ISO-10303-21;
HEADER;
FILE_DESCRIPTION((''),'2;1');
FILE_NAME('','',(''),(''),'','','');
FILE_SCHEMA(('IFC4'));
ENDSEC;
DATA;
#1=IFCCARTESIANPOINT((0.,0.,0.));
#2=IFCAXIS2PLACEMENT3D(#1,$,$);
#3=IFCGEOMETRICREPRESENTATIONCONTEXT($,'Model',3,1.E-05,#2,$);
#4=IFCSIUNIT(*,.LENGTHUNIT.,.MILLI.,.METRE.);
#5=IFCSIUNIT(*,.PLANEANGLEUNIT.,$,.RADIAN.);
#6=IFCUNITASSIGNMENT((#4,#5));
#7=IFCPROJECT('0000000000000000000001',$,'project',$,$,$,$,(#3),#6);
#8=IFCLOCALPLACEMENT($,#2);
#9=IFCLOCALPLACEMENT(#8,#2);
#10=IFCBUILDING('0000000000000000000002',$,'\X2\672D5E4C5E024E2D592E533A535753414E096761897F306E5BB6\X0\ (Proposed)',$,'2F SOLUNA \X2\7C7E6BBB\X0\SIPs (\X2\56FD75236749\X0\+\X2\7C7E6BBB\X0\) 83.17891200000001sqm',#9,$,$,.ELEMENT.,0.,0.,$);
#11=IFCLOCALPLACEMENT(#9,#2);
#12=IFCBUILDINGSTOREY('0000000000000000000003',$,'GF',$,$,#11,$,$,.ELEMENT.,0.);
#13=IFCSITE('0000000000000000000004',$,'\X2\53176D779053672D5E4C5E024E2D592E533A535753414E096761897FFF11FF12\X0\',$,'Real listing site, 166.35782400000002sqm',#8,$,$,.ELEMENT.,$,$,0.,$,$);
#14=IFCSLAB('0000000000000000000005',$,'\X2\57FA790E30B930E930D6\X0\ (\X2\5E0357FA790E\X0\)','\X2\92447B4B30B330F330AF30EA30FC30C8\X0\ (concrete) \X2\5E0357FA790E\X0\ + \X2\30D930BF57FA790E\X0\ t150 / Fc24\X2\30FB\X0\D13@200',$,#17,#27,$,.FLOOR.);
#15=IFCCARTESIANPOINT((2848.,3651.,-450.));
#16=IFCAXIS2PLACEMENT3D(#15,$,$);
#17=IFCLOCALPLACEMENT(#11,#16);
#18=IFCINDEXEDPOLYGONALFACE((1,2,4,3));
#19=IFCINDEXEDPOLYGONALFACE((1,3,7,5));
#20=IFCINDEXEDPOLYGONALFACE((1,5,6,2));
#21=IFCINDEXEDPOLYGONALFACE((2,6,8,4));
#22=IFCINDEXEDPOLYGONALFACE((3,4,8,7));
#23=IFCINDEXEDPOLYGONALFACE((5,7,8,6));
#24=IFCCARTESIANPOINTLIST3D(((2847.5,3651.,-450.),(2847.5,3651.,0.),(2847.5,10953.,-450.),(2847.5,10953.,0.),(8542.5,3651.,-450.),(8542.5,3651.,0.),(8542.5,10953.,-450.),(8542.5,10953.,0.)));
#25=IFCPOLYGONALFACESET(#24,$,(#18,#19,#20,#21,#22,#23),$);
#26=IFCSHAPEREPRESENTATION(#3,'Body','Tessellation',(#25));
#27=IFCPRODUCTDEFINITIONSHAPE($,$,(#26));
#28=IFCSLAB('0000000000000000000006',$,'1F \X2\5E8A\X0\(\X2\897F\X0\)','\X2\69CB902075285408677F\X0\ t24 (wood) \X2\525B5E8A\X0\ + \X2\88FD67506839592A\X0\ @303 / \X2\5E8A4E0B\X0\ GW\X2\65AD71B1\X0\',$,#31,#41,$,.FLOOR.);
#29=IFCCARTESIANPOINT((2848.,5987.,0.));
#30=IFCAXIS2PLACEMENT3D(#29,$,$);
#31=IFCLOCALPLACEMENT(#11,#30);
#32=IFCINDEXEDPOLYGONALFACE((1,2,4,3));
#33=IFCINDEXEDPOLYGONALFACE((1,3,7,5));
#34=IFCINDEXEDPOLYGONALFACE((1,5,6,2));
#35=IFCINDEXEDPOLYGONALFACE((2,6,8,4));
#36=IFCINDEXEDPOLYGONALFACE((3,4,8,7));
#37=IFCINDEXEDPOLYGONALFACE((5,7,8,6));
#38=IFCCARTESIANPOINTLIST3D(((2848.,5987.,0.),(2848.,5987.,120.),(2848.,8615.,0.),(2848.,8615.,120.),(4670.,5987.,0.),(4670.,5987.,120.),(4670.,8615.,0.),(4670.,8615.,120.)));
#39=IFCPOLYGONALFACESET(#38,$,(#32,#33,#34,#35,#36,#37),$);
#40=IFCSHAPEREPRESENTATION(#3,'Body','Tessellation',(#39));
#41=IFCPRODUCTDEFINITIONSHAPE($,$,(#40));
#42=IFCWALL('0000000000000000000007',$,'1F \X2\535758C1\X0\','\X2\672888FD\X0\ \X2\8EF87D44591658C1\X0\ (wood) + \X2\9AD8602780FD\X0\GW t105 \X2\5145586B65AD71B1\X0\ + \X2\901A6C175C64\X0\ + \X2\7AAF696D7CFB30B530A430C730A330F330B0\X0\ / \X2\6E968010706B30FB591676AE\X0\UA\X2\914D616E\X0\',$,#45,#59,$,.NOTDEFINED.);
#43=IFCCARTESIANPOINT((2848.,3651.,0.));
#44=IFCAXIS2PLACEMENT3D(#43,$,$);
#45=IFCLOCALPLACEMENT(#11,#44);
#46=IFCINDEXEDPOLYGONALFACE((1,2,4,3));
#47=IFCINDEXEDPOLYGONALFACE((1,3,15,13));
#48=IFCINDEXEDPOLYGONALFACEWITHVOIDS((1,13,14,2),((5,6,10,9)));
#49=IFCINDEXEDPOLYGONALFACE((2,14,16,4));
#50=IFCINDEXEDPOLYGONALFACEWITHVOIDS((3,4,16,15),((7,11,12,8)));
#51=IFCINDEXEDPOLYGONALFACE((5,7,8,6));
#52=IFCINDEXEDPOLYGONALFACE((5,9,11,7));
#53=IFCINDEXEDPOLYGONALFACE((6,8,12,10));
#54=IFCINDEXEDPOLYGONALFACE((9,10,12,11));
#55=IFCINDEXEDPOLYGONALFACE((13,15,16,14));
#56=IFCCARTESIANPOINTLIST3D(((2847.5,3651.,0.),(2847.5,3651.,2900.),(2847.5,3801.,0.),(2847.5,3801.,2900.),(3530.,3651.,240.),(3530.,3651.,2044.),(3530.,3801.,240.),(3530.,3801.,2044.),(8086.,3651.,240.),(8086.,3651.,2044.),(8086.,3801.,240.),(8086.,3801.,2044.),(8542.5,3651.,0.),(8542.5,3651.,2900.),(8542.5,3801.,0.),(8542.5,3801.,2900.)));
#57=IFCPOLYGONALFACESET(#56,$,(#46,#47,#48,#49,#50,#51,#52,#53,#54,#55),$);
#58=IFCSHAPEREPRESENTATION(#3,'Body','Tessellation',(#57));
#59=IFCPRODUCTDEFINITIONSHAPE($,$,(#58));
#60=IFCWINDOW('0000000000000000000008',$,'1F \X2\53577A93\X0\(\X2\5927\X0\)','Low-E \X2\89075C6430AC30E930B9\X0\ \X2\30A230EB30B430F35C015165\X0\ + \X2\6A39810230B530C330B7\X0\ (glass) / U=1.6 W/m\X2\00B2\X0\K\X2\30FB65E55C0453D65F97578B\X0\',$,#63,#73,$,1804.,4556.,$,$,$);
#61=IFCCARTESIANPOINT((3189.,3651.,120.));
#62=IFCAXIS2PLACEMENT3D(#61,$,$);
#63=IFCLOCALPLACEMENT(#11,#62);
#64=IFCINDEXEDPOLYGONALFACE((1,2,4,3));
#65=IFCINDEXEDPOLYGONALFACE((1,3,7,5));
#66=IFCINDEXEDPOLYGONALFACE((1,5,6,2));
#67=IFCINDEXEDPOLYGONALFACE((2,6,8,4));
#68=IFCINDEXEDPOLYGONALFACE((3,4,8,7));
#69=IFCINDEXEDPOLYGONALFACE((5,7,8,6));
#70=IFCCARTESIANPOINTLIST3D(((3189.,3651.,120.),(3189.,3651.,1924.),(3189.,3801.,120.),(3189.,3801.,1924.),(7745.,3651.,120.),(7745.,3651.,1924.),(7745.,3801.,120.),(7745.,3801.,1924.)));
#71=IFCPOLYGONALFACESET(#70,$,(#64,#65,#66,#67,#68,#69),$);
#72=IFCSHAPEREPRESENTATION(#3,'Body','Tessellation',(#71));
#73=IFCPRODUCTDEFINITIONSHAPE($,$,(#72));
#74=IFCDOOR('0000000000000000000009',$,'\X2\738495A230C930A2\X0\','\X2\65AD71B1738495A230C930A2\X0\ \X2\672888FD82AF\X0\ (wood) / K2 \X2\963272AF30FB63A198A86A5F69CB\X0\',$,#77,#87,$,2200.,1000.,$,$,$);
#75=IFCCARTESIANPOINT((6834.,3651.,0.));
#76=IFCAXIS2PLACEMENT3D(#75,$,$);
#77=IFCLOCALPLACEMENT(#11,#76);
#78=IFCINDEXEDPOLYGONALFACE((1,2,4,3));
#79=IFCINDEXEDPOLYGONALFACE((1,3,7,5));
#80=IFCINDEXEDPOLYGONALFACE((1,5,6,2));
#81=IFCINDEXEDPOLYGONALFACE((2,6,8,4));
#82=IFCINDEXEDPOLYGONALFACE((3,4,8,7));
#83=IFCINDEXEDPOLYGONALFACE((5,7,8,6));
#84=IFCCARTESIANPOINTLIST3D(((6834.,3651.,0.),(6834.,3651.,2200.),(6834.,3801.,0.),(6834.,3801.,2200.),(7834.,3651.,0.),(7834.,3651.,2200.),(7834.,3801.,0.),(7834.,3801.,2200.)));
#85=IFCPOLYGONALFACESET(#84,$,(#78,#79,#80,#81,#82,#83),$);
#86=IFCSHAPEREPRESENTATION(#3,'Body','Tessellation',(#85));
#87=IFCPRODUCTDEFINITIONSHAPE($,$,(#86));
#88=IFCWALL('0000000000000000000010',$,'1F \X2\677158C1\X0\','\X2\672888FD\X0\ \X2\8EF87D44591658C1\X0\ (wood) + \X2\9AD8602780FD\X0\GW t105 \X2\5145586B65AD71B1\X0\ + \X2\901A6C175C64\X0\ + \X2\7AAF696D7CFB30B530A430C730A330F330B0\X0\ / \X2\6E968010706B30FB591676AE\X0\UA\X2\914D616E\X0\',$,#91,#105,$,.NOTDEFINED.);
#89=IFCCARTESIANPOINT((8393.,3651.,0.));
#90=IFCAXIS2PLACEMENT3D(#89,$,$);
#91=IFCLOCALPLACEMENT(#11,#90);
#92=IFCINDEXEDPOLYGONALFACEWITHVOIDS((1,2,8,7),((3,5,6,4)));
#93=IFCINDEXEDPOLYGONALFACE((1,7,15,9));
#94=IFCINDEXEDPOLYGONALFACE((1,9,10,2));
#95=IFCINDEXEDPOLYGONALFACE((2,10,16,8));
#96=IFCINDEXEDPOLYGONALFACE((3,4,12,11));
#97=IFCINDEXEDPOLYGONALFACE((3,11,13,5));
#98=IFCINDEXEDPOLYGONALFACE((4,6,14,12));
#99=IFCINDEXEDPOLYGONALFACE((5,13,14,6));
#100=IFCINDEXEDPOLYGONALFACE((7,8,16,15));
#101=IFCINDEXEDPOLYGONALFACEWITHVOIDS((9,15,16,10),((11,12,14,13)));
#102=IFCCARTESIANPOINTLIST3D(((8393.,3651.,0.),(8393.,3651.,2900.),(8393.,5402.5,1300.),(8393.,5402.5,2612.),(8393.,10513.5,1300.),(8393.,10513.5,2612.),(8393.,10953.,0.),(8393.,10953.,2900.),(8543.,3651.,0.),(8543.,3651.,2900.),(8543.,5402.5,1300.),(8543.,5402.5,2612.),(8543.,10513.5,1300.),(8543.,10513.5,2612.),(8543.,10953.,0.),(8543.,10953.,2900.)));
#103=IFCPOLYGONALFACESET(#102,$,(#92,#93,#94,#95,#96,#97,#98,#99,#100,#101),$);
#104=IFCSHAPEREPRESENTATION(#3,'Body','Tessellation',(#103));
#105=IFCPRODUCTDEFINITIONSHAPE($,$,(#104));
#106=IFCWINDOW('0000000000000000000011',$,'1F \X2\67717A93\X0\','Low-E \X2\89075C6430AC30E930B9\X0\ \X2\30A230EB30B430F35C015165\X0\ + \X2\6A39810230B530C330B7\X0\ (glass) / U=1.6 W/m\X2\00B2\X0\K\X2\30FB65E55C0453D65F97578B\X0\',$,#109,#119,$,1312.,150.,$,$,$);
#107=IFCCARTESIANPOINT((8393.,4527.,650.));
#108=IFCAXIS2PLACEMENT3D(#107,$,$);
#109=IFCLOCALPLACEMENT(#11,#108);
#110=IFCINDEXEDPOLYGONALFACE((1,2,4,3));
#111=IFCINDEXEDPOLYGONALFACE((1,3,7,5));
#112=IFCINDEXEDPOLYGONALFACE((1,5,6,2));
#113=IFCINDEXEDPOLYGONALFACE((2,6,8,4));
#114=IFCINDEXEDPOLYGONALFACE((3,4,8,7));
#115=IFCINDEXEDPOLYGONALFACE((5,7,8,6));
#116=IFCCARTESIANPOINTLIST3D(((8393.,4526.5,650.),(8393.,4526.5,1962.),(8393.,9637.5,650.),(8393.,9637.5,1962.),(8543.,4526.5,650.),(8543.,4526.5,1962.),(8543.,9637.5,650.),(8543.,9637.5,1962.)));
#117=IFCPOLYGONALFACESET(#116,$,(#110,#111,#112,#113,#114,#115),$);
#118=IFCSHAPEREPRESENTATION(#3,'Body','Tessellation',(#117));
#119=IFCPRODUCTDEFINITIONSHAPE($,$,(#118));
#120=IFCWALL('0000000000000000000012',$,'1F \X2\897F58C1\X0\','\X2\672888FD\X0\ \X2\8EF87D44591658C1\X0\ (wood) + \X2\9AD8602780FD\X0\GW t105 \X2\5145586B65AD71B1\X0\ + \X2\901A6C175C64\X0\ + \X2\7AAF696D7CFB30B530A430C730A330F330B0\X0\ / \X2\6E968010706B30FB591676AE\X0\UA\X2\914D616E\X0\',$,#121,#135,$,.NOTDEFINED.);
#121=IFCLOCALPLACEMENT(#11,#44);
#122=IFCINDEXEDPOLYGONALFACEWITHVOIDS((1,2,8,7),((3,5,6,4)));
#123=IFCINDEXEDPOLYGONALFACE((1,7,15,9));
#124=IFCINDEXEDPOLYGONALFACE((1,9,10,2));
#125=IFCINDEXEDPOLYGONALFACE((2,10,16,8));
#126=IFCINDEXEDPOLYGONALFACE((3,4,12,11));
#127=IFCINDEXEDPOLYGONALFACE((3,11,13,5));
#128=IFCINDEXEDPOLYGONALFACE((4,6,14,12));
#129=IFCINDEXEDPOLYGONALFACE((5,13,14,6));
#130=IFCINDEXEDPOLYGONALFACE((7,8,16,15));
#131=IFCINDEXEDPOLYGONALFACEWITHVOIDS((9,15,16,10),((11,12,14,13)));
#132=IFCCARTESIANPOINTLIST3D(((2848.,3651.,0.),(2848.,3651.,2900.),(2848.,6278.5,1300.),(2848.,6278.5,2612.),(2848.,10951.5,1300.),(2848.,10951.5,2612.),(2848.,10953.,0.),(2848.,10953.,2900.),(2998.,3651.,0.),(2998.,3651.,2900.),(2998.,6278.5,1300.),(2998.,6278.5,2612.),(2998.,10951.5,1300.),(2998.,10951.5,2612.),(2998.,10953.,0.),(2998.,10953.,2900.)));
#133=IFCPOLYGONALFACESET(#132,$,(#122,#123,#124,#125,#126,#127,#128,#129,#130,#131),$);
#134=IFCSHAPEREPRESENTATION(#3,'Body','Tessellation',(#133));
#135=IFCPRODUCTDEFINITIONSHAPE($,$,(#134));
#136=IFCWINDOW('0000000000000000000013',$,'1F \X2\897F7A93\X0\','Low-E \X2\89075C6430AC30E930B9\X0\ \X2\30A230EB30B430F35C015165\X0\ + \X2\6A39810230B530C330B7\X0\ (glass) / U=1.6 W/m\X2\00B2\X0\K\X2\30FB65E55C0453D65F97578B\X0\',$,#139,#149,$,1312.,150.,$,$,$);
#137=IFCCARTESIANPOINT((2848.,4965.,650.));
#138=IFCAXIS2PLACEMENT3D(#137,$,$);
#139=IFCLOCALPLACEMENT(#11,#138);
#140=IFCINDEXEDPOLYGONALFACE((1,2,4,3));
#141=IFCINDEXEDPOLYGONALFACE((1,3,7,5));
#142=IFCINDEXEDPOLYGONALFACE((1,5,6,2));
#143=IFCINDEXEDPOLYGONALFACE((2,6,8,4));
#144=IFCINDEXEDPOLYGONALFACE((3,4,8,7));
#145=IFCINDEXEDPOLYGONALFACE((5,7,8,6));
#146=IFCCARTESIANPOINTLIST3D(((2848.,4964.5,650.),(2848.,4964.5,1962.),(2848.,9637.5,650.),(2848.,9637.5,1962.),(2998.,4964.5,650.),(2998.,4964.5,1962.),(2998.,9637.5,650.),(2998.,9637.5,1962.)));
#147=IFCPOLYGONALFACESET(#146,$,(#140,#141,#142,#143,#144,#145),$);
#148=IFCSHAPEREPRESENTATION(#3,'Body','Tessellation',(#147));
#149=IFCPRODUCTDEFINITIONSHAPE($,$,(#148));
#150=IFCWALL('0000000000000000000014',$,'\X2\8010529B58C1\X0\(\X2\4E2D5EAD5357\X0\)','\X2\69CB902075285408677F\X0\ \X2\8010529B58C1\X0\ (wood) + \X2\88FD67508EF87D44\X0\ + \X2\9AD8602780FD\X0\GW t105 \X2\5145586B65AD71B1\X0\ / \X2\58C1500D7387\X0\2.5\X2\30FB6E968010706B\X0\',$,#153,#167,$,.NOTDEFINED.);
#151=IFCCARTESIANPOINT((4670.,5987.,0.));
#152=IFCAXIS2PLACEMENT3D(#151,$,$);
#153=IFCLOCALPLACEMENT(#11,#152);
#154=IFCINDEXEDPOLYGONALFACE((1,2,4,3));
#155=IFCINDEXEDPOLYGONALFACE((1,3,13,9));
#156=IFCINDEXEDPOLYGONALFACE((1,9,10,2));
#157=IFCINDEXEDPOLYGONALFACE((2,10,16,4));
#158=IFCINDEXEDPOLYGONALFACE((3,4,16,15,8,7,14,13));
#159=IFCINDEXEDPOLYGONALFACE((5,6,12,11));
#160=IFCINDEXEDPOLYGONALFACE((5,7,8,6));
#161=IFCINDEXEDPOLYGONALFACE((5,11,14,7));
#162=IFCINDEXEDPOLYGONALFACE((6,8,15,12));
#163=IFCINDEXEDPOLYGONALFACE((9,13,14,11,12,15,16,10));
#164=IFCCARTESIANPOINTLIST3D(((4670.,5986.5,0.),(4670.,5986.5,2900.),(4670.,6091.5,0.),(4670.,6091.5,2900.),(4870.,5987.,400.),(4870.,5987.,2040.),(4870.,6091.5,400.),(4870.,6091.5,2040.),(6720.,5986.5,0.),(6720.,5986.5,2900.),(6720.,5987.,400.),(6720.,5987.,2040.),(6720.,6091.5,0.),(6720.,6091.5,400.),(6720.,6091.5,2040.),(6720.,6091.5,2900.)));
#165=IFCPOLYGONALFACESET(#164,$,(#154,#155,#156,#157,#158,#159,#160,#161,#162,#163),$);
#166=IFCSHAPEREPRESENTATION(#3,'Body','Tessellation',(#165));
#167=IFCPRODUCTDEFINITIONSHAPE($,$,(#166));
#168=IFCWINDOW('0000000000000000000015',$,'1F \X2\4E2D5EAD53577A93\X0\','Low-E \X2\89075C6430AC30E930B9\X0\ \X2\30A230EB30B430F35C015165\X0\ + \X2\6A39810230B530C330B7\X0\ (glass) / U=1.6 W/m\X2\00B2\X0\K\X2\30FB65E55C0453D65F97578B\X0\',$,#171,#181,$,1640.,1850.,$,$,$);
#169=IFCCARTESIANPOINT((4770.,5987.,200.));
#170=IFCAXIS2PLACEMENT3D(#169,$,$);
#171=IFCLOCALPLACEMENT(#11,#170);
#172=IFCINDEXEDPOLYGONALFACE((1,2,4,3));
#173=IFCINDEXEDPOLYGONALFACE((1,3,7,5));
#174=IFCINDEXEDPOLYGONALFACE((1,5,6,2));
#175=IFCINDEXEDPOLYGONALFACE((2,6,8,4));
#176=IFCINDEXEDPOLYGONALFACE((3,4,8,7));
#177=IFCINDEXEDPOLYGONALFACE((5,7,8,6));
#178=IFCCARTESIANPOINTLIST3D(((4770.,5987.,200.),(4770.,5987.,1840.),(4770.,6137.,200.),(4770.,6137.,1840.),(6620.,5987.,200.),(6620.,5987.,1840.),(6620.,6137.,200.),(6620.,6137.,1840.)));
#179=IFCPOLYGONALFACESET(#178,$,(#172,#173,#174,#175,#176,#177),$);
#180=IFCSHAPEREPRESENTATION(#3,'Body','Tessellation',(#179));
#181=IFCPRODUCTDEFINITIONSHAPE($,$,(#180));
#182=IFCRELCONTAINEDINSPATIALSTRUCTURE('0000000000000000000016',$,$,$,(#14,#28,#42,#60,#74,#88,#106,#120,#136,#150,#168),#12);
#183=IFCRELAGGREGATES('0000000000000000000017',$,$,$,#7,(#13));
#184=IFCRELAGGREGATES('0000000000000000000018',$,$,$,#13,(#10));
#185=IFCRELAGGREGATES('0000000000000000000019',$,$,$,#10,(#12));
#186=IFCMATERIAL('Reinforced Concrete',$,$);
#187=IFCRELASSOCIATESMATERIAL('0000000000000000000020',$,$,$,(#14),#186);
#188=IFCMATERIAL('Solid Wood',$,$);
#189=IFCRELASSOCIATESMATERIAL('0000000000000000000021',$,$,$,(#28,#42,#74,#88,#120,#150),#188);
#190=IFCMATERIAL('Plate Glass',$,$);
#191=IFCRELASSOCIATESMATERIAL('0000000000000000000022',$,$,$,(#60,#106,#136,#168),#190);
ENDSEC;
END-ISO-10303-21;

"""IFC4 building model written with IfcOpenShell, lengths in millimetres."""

from ifc_helpers import new_model, si_unit, frame, frame_2d, origin, place, context, project, spatial, rectangle, extrude, material, element, fill, save


model = new_model("IFC4")

# Units and contexts
model_context = context("Model", 3, precision=1e-05, world=origin())
ifc_project = project(units=[si_unit("LENGTHUNIT", "METRE", prefix="MILLI"), si_unit("PLANEANGLEUNIT", "RADIAN")], contexts=[model_context])

# Site, building, storey
site_placement = place(None, origin())
site = spatial("IfcSite", under=ifc_project, at=site_placement, Name="北海道札幌市中央区南十三条西１２", ObjectType="Real listing site, 166.35782400000002sqm", CompositionType="ELEMENT", RefElevation=0.0)
building_placement = place(site_placement, origin())
building = spatial("IfcBuilding", under=site, at=building_placement, Name="札幌市中央区南十三条西の家 (Proposed)", ObjectType="2F SOLUNA 籾殻SIPs (国産杉+籾殻) 83.17891200000001sqm", CompositionType="ELEMENT", ElevationOfRefHeight=0.0, ElevationOfTerrain=0.0)
storey_placement = place(building_placement, origin())
storey = spatial("IfcBuildingStorey", under=building, at=storey_placement, Name="GF", CompositionType="ELEMENT", Elevation=0.0)

# Slabs
ifc_material_1 = material(Name="Reinforced Concrete")
slab_1_placement = place(storey_placement, frame((2848.0, 3651.0, -450.0)))
element("IfcSlab", 1, at=slab_1_placement, inside=storey, material=ifc_material_1, Name="基礎スラブ (布基礎)", Description="鉄筋コンクリート (concrete) 布基礎 + ベタ基礎 t150 / Fc24・D13@200", PredefinedType="FLOOR", context=model_context, shape_type="SweptSolid", body=[
    extrude(rectangle(XDim=5695.0, YDim=7302.0, at=frame_2d((2847.0, 3651.0))), frame((2848.0, 3651.0, -450.0)), (0.0, 0.0, 1.0), 450.0),
])
ifc_material_2 = material(Name="Solid Wood")
slab_2_placement = place(storey_placement, frame((2848.0, 5987.0, 0.0)))
element("IfcSlab", 2, at=slab_2_placement, inside=storey, material=ifc_material_2, Name="1F 床(西)", Description="構造用合板 t24 (wood) 剛床 + 製材根太 @303 / 床下 GW断熱", PredefinedType="FLOOR", context=model_context, shape_type="SweptSolid", body=[
    extrude(rectangle(XDim=1822.0, YDim=2628.0, at=frame_2d((911.0, 1314.0))), frame((2848.0, 5987.0, 0.0)), (0.0, 0.0, 1.0), 120.0),
])

# Wall, openings, window, door
wall_1_placement = place(storey_placement, frame((2848.0, 3651.0, 0.0)))
wall_1 = element("IfcWall", 3, at=wall_1_placement, inside=storey, material=ifc_material_2, Name="1F 南壁", Description="木製 軸組外壁 (wood) + 高性能GW t105 充填断熱 + 通気層 + 窯業系サイディング / 準耐火・外皮UA配慮", PredefinedType="NOTDEFINED", context=model_context, shape_type="SweptSolid", body=[
    extrude(rectangle(XDim=5695.0, YDim=150.0, at=frame_2d((2847.0, 75.0))), frame((2848.0, 3651.0, 0.0)), (0.0, 0.0, 1.0), 2900.0),
])
opening_1_placement = place(storey_placement, frame((3189.0, 3651.0, 120.0)))
opening_1 = element("IfcOpeningElement", 4, at=opening_1_placement, cuts=wall_1, PredefinedType="NOTDEFINED", context=model_context, shape_type="SweptSolid", body=[
    extrude(rectangle(XDim=4556.0, YDim=150.0, at=frame_2d((2278.0, 75.0))), frame((3189.0, 3651.0, 120.0)), (0.0, 0.0, 1.0), 1804.0),
])
opening_2_placement = place(storey_placement, frame((6834.0, 3651.0, 0.0)))
opening_2 = element("IfcOpeningElement", 5, at=opening_2_placement, cuts=wall_1, PredefinedType="NOTDEFINED", context=model_context, shape_type="SweptSolid", body=[
    extrude(rectangle(XDim=1000.0, YDim=150.0, at=frame_2d((500.0, 75.0))), frame((6834.0, 3651.0, 0.0)), (0.0, 0.0, 1.0), 2200.0),
])
ifc_material_3 = material(Name="Plate Glass")
window_1_placement = place(storey_placement, frame((3189.0, 3651.0, 120.0)))
window_1 = element("IfcWindow", 6, at=window_1_placement, inside=storey, material=ifc_material_3, Name="1F 南窓(大)", Description="Low-E 複層ガラス アルゴン封入 + 樹脂サッシ (glass) / U=1.6 W/m²K・日射取得型", OverallHeight=1804.0, OverallWidth=4556.0, context=model_context, shape_type="SweptSolid", body=[
    extrude(rectangle(XDim=4556.0, YDim=150.0, at=frame_2d((2278.0, 75.0))), frame((3189.0, 3651.0, 120.0)), (0.0, 0.0, 1.0), 1804.0),
])
fill(opening_1, window_1)
door_placement = place(storey_placement, frame((6834.0, 3651.0, 0.0)))
door = element("IfcDoor", 7, at=door_placement, inside=storey, material=ifc_material_2, Name="玄関ドア", Description="断熱玄関ドア 木製芯 (wood) / K2 防犯・採風機構", OverallHeight=2200.0, OverallWidth=1000.0, context=model_context, shape_type="SweptSolid", body=[
    extrude(rectangle(XDim=1000.0, YDim=150.0, at=frame_2d((500.0, 75.0))), frame((6834.0, 3651.0, 0.0)), (0.0, 0.0, 1.0), 2200.0),
])
fill(opening_2, door)

# Walls, openings, windows
wall_2_placement = place(storey_placement, frame((8393.0, 3651.0, 0.0)))
wall_2 = element("IfcWall", 8, at=wall_2_placement, inside=storey, material=ifc_material_2, Name="1F 東壁", Description="木製 軸組外壁 (wood) + 高性能GW t105 充填断熱 + 通気層 + 窯業系サイディング / 準耐火・外皮UA配慮", PredefinedType="NOTDEFINED", context=model_context, shape_type="SweptSolid", body=[
    extrude(rectangle(XDim=150.0, YDim=7302.0, at=frame_2d((75.0, 3651.0))), frame((8393.0, 3651.0, 0.0)), (0.0, 0.0, 1.0), 2900.0),
])
opening_3_placement = place(storey_placement, frame((8393.0, 4527.0, 650.0)))
opening_3 = element("IfcOpeningElement", 9, at=opening_3_placement, cuts=wall_2, PredefinedType="NOTDEFINED", context=model_context, shape_type="SweptSolid", body=[
    extrude(rectangle(XDim=150.0, YDim=5111.0, at=frame_2d((75.0, 2555.0))), frame((8393.0, 4527.0, 650.0)), (0.0, 0.0, 1.0), 1312.0),
])
window_2_placement = place(storey_placement, frame((8393.0, 4527.0, 650.0)))
window_2 = element("IfcWindow", 10, at=window_2_placement, inside=storey, material=ifc_material_3, Name="1F 東窓", Description="Low-E 複層ガラス アルゴン封入 + 樹脂サッシ (glass) / U=1.6 W/m²K・日射取得型", OverallHeight=1312.0, OverallWidth=150.0, context=model_context, shape_type="SweptSolid", body=[
    extrude(rectangle(XDim=150.0, YDim=5111.0, at=frame_2d((75.0, 2555.0))), frame((8393.0, 4527.0, 650.0)), (0.0, 0.0, 1.0), 1312.0),
])
fill(opening_3, window_2)
wall_3_placement = place(storey_placement, frame((2848.0, 3651.0, 0.0)))
wall_3 = element("IfcWall", 11, at=wall_3_placement, inside=storey, material=ifc_material_2, Name="1F 西壁", Description="木製 軸組外壁 (wood) + 高性能GW t105 充填断熱 + 通気層 + 窯業系サイディング / 準耐火・外皮UA配慮", PredefinedType="NOTDEFINED", context=model_context, shape_type="SweptSolid", body=[
    extrude(rectangle(XDim=150.0, YDim=7302.0, at=frame_2d((75.0, 3651.0))), frame((2848.0, 3651.0, 0.0)), (0.0, 0.0, 1.0), 2900.0),
])
opening_4_placement = place(storey_placement, frame((2848.0, 4965.0, 650.0)))
opening_4 = element("IfcOpeningElement", 12, at=opening_4_placement, cuts=wall_3, PredefinedType="NOTDEFINED", context=model_context, shape_type="SweptSolid", body=[
    extrude(rectangle(XDim=150.0, YDim=4673.0, at=frame_2d((75.0, 2336.0))), frame((2848.0, 4965.0, 650.0)), (0.0, 0.0, 1.0), 1312.0),
])
window_3_placement = place(storey_placement, frame((2848.0, 4965.0, 650.0)))
window_3 = element("IfcWindow", 13, at=window_3_placement, inside=storey, material=ifc_material_3, Name="1F 西窓", Description="Low-E 複層ガラス アルゴン封入 + 樹脂サッシ (glass) / U=1.6 W/m²K・日射取得型", OverallHeight=1312.0, OverallWidth=150.0, context=model_context, shape_type="SweptSolid", body=[
    extrude(rectangle(XDim=150.0, YDim=4673.0, at=frame_2d((75.0, 2336.0))), frame((2848.0, 4965.0, 650.0)), (0.0, 0.0, 1.0), 1312.0),
])
fill(opening_4, window_3)
wall_4_placement = place(storey_placement, frame((4670.0, 5987.0, 0.0)))
wall_4 = element("IfcWall", 14, at=wall_4_placement, inside=storey, material=ifc_material_2, Name="耐力壁(中庭南)", Description="構造用合板 耐力壁 (wood) + 製材軸組 + 高性能GW t105 充填断熱 / 壁倍率2.5・準耐火", PredefinedType="NOTDEFINED", context=model_context, shape_type="SweptSolid", body=[
    extrude(rectangle(XDim=2050.0, YDim=105.0, at=frame_2d((1025.0, 52.0))), frame((4670.0, 5987.0, 0.0)), (0.0, 0.0, 1.0), 2900.0),
])
opening_5_placement = place(storey_placement, frame((4770.0, 5987.0, 200.0)))
opening_5 = element("IfcOpeningElement", 15, at=opening_5_placement, cuts=wall_4, PredefinedType="NOTDEFINED", context=model_context, shape_type="SweptSolid", body=[
    extrude(rectangle(XDim=1850.0, YDim=150.0, at=frame_2d((925.0, 75.0))), frame((4770.0, 5987.0, 200.0)), (0.0, 0.0, 1.0), 1640.0),
])
window_4_placement = place(storey_placement, frame((4770.0, 5987.0, 200.0)))
window_4 = element("IfcWindow", 16, at=window_4_placement, inside=storey, material=ifc_material_3, Name="1F 中庭南窓", Description="Low-E 複層ガラス アルゴン封入 + 樹脂サッシ (glass) / U=1.6 W/m²K・日射取得型", OverallHeight=1640.0, OverallWidth=1850.0, context=model_context, shape_type="SweptSolid", body=[
    extrude(rectangle(XDim=1850.0, YDim=150.0, at=frame_2d((925.0, 75.0))), frame((4770.0, 5987.0, 200.0)), (0.0, 0.0, 1.0), 1640.0),
])
fill(opening_5, window_4)

save(model, "model.ifc")
